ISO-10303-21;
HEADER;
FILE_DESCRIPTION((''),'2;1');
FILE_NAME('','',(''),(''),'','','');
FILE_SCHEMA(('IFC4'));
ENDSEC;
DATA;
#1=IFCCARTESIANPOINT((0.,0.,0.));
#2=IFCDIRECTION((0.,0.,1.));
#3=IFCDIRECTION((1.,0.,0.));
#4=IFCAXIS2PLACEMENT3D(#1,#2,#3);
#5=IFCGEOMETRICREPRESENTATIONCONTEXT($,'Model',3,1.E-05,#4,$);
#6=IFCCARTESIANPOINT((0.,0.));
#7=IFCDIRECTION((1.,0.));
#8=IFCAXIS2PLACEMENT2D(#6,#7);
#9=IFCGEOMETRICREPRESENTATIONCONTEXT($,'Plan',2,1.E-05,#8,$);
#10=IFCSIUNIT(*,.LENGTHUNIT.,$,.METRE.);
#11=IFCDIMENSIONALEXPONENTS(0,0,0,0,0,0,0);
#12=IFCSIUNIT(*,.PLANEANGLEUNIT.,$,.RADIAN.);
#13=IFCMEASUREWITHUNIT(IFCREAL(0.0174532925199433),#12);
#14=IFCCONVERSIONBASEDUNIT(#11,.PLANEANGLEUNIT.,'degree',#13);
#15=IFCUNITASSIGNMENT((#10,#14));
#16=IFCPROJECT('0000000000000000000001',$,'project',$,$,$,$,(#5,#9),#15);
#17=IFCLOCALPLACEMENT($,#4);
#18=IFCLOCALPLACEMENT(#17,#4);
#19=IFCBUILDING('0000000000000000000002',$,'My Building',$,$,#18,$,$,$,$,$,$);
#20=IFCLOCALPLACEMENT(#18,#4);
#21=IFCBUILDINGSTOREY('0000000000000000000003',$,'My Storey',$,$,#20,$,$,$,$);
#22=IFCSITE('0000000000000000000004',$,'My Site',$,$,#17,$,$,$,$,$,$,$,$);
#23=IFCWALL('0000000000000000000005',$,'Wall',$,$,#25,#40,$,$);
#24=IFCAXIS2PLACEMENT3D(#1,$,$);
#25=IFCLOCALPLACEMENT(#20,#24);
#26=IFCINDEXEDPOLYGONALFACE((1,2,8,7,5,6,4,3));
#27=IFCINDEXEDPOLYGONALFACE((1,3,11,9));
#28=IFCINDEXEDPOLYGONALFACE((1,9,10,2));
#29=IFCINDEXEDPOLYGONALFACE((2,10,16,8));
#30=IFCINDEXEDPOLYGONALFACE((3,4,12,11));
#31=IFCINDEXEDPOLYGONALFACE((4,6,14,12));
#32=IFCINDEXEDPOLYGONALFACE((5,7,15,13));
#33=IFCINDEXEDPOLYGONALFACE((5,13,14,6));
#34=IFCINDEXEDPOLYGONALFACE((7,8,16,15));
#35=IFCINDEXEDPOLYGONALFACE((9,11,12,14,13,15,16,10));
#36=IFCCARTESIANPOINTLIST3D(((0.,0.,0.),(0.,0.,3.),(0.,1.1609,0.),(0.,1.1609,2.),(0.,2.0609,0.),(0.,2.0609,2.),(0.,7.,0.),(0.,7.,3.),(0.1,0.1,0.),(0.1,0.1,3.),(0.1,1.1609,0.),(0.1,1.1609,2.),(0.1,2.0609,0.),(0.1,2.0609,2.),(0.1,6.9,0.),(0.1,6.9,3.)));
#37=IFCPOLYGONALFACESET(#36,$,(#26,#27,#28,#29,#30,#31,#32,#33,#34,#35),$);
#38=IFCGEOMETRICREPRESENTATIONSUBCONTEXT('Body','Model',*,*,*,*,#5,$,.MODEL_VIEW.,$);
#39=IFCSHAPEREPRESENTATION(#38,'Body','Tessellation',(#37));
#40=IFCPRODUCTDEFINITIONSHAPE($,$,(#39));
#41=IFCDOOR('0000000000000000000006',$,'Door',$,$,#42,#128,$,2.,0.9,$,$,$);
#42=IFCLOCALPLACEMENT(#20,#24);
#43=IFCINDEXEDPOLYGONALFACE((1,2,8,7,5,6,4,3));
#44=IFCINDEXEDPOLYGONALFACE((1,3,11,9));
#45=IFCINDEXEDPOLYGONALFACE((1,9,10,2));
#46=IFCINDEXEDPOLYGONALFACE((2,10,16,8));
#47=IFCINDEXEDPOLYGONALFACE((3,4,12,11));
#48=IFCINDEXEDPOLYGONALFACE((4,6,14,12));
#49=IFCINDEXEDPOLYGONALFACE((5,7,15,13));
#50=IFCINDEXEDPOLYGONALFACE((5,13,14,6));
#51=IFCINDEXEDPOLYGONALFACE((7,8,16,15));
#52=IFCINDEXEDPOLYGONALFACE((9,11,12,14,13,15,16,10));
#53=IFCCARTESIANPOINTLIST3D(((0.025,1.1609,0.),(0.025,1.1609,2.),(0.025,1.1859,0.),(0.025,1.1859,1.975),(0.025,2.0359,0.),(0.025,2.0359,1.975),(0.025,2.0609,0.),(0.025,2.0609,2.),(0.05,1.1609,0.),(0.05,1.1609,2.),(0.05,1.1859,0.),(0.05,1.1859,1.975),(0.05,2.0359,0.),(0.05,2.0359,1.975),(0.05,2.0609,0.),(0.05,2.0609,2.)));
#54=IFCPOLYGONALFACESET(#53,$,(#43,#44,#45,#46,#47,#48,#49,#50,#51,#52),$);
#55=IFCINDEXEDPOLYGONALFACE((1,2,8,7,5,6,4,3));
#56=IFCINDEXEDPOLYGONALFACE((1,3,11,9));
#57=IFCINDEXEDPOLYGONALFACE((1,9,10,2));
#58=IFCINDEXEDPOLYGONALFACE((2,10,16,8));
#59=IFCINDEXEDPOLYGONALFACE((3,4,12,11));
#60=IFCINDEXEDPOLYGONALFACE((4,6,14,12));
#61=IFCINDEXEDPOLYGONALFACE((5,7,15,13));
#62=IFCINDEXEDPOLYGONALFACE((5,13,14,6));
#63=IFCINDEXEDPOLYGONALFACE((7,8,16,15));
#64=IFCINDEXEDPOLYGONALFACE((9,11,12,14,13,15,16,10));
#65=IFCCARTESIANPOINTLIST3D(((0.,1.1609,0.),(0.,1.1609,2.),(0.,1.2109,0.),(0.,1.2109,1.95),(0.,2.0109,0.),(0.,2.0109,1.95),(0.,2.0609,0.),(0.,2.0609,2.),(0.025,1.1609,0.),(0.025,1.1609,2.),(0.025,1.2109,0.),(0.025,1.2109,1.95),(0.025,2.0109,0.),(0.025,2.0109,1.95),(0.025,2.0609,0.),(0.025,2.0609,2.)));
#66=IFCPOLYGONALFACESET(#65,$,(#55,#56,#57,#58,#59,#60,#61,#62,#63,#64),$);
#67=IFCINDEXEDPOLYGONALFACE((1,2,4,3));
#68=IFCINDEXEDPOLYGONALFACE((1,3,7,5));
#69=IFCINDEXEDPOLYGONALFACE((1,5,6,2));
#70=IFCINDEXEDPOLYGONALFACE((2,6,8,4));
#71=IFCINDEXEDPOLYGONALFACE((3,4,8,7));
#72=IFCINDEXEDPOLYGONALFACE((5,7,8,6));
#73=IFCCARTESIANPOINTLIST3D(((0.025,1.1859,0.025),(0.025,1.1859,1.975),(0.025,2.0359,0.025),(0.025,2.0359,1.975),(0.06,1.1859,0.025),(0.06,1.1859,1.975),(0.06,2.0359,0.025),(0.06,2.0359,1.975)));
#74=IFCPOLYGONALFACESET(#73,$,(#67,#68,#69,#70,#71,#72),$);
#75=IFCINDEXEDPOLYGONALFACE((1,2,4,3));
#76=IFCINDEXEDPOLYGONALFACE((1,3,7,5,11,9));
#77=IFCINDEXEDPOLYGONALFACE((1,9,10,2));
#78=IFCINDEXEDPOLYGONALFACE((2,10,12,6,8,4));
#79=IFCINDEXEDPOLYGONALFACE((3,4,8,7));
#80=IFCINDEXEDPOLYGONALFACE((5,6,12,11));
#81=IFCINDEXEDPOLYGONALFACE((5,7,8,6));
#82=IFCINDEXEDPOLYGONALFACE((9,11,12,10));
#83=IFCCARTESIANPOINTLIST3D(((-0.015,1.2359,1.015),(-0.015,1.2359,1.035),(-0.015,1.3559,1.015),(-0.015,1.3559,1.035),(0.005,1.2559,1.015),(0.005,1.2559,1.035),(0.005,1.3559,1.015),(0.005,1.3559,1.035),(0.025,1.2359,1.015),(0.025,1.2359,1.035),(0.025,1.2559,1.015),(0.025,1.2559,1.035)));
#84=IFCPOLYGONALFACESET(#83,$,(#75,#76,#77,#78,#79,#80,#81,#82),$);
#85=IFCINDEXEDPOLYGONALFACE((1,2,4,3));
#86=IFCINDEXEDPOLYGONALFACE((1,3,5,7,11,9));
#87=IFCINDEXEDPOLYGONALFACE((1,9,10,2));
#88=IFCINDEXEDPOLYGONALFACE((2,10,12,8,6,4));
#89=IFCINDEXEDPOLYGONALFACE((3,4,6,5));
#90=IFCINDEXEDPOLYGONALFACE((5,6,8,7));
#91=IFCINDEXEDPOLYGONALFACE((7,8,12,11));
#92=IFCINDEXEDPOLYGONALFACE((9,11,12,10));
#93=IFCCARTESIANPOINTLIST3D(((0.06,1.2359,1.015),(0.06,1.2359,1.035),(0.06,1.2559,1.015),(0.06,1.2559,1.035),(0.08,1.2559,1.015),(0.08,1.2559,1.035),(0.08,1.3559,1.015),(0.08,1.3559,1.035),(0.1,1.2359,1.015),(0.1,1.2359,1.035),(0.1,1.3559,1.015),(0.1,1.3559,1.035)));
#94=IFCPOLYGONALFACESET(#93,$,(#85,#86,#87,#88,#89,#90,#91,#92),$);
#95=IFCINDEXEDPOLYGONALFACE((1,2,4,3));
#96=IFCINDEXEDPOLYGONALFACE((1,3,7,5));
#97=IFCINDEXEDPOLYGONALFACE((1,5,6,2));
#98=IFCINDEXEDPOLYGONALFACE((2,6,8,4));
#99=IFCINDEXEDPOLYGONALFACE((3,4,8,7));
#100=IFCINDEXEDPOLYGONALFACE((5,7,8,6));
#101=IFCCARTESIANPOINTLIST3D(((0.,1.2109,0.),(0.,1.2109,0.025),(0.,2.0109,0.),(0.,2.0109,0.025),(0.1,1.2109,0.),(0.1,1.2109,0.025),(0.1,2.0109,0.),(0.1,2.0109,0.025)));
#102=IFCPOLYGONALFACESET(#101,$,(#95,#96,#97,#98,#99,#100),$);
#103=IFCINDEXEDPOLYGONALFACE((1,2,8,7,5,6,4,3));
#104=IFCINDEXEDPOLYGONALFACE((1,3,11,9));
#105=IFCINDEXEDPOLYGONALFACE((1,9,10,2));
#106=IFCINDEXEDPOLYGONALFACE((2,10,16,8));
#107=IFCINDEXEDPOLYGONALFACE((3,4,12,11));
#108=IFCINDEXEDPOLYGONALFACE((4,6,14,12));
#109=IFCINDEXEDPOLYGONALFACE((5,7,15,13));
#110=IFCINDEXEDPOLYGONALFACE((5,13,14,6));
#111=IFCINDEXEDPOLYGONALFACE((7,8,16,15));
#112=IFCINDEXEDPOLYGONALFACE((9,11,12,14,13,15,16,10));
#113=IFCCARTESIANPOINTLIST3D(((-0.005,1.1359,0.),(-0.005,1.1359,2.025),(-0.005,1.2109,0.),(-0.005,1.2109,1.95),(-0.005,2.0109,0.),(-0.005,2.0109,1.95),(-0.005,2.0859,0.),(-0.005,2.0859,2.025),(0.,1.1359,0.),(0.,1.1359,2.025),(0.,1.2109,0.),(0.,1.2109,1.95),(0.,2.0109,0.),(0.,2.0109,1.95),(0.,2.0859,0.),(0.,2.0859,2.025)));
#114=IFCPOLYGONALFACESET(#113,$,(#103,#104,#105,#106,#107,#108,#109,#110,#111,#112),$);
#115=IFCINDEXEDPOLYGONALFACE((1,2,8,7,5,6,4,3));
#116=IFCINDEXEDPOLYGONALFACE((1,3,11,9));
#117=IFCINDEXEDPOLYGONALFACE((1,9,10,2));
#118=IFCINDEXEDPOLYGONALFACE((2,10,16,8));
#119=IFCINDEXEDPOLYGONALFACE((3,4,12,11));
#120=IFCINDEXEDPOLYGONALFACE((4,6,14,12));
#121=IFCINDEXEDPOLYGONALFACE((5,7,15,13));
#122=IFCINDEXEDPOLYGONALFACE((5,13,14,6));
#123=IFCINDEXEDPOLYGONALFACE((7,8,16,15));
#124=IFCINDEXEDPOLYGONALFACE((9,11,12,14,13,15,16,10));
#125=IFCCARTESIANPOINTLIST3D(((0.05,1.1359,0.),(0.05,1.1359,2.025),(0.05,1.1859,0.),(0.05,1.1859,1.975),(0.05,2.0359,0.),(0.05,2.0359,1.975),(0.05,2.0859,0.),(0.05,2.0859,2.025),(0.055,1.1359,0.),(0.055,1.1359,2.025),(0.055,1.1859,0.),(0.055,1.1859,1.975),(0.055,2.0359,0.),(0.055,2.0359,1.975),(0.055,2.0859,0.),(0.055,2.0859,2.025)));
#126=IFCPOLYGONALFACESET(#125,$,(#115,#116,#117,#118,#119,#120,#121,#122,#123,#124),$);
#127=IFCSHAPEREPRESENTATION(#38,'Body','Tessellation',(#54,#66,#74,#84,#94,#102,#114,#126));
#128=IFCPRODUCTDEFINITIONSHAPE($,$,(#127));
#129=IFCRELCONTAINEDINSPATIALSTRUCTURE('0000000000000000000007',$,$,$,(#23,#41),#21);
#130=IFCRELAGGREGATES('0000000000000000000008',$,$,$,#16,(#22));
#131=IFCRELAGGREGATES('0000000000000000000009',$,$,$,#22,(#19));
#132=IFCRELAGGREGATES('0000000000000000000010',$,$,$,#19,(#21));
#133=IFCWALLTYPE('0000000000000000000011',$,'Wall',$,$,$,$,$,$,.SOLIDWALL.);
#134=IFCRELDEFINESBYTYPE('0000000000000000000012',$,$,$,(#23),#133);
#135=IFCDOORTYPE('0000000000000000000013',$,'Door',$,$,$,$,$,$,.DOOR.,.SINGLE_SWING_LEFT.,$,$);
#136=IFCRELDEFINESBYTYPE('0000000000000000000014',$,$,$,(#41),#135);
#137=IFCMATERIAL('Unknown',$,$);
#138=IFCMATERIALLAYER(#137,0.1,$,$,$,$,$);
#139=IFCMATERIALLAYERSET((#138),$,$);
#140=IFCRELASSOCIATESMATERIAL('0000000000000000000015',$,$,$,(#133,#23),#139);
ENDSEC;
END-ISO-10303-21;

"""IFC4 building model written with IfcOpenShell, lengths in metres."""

from ifc_helpers import new_model, entity, si_unit, converted_unit, frame, origin_with_axes, origin_2d_with_axis, place, context, subcontext, project, spatial, line, indexed_curve, outline, extrude, shape, source, transform, mapped, material, layer, layer_set, layer_usage, type_object, type_shapes, element, fill, save


model = new_model("IFC4")

# Units and contexts
model_context = context("Model", 3, precision=1e-05, world=origin_with_axes())
plan_context = context("Plan", 2, precision=1e-05, world=origin_2d_with_axis())
body_context_1 = subcontext(model_context, "Body", "Model", "MODEL_VIEW")
body_context_2 = subcontext(plan_context, "Body", "Plan", "PLAN_VIEW")
ifc_project = project(units=[si_unit("LENGTHUNIT", "METRE"), converted_unit("PLANEANGLEUNIT", "degree", entity("IfcReal", 0.0174532925199433), si_unit("PLANEANGLEUNIT", "RADIAN"), dimensions=[0, 0, 0, 0, 0, 0, 0])], contexts=[model_context, plan_context])

# Site, building, storey
site_placement = place(None, origin_with_axes())
site = spatial("IfcSite", under=ifc_project, at=site_placement, Name="My Site")
building_placement = place(site_placement, origin_with_axes())
building = spatial("IfcBuilding", under=site, at=building_placement, Name="My Building")
storey_placement = place(building_placement, origin_with_axes())
storey = spatial("IfcBuildingStorey", under=building, at=storey_placement, Name="My Storey")

# Shared definitions
ifc_material = material(Name="Unknown")

# Shared definitions
ifc_layer_1 = layer(ifc_material, 0.1)
ifc_layer_set_1 = layer_set([ifc_layer_1])
wall_type = type_object("IfcWallType", Name="Wall", PredefinedType="SOLIDWALL", material=ifc_layer_set_1)
shared_shape_1 = source(origin_with_axes(), body_context_1, "Body", "SweptSolid", [
    extrude(outline(indexed_curve([(0.0, 0.0), (0.9, 0.0), (0.9, 2.0), (0.0, 2.0)], segments=[line(1, 2, 3, 4, 1)])), frame((0.0, -0.6, 0.0), z_axis=(0.0, -1.0, 0.0), x_axis=(1.0, 0.0, 0.0)), (0.0, 0.0, -1.0), 1.2),
])
door_type = type_object("IfcDoorType", Name="Door", OperationType="SINGLE_SWING_LEFT", PredefinedType="DOOR")
shared_shape_2 = source(origin_with_axes(), body_context_1, "Body", "SweptSolid", [
    extrude(outline(indexed_curve([(0.0, 0.0), (0.0, 2.0), (0.9, 2.0), (0.9, 0.0), (0.875, 0.0), (0.875, 1.975), (0.025, 1.975), (0.025, 0.0)], segments=[line(1, 2, 3, 4, 5, 6, 7, 8, 1)])), frame((0.0, 0.025, 0.0), z_axis=(0.0, -1.0, 0.0), x_axis=(1.0, 0.0, 0.0)), (0.0, 0.0, -1.0), 0.025),
    extrude(outline(indexed_curve([(0.0, 0.0), (0.0, 2.0), (0.9, 2.0), (0.9, 0.0), (0.85, 0.0), (0.85, 1.95), (0.05, 1.95), (0.05, 0.0)], segments=[line(1, 2, 3, 4, 5, 6, 7, 8, 1)])), frame((0.0, 0.0, 0.0), z_axis=(0.0, -1.0, 0.0), x_axis=(1.0, 0.0, 0.0)), (0.0, 0.0, -1.0), 0.025),
    extrude(outline(indexed_curve([(0.0, 0.0), (0.85, 0.0), (0.85, 0.035), (0.0, 0.035)], segments=[line(1, 2, 3, 4, 1)])), frame((0.025, 0.025, 0.025), z_axis=(0.0, 0.0, 1.0), x_axis=(1.0, 0.0, 0.0)), (0.0, 0.0, 1.0), 1.95),
    extrude(outline(indexed_curve([(0.0, 0.0), (0.0, -0.04), (-0.12, -0.04), (-0.12, -0.02), (-0.02, -0.02), (-0.02, 0.0)], segments=[line(1, 2, 3, 4, 5, 6, 1)])), frame((0.825, 0.025, 1.015), z_axis=(0.0, 0.0, 1.0), x_axis=(1.0, 0.0, 0.0)), (0.0, 0.0, 1.0), 0.02),
    extrude(outline(indexed_curve([(0.0, 0.0), (0.0, 0.04), (-0.12, 0.04), (-0.12, 0.02), (-0.02, 0.02), (-0.02, 0.0)], segments=[line(1, 2, 3, 4, 5, 6, 1)])), frame((0.825, 0.06, 1.015), z_axis=(0.0, 0.0, 1.0), x_axis=(1.0, 0.0, 0.0)), (0.0, 0.0, 1.0), 0.02),
    extrude(outline(indexed_curve([(0.0, 0.0), (0.8, 0.0), (0.8, 0.1), (0.0, 0.1)], segments=[line(1, 2, 3, 4, 1)])), frame((0.05, 0.0, 0.0), z_axis=(0.0, 0.0, 1.0), x_axis=(1.0, 0.0, 0.0)), (0.0, 0.0, 1.0), 0.025),
    extrude(outline(indexed_curve([(0.0, 0.0), (0.0, 2.025), (0.95, 2.025), (0.95, 0.0), (0.875, 0.0), (0.875, 1.95), (0.075, 1.95), (0.075, 0.0)], segments=[line(1, 2, 3, 4, 5, 6, 7, 8, 1)])), frame((-0.025, -0.005, 0.0), z_axis=(0.0, -1.0, 0.0), x_axis=(1.0, 0.0, 0.0)), (0.0, 0.0, -1.0), 0.005),
    extrude(outline(indexed_curve([(0.0, 0.0), (0.0, 2.025), (0.95, 2.025), (0.95, 0.0), (0.9, 0.0), (0.9, 1.975), (0.05, 1.975), (0.05, 0.0)], segments=[line(1, 2, 3, 4, 5, 6, 7, 8, 1)])), frame((-0.025, 0.05, 0.0), z_axis=(0.0, -1.0, 0.0), x_axis=(1.0, 0.0, 0.0)), (0.0, 0.0, -1.0), 0.005),
])
shared_shape_3 = source(origin_with_axes(), body_context_2, "Body", "Curve2D", [
    entity("IfcIndexedPolyCurve", entity("IfcCartesianPointList2D", [[0.0, 0.0], [0.0, 0.05], [0.025, 0.05], [0.025, 0.025], [0.05, 0.025], [0.05, 0.0]]), [entity("IfcLineIndex", [1, 2, 3, 4, 5, 6, 1])]),
    entity("IfcIndexedPolyCurve", entity("IfcCartesianPointList2D", [[0.9, 0.0], [0.9, 0.05], [0.875, 0.05], [0.875, 0.025], [0.85, 0.025], [0.85, 0.0]]), [entity("IfcLineIndex", [1, 2, 3, 4, 5, 6, 1])]),
    entity("IfcTrimmedCurve", entity("IfcEllipse", entity("IfcAxis2Placement2D", entity("IfcCartesianPoint", [0.06, 0.05]), entity("IfcDirection", [1.0, 0.0])), 0.815, 0.85), [entity("IfcCartesianPoint", [0.875, 0.05])], [entity("IfcCartesianPoint", [0.06, 0.9])], True, "CARTESIAN"),
    entity("IfcIndexedPolyCurve", entity("IfcCartesianPointList2D", [[0.025, 0.05], [0.06, 0.05], [0.06, 0.9], [0.025, 0.9]]), [entity("IfcLineIndex", [1, 2, 3, 4, 1])]),
])
type_shapes(door_type, [shared_shape_2, shared_shape_3])

# Wall, opening, door
ifc_layer_usage_1 = layer_usage(ifc_layer_set_1, "AXIS2", "POSITIVE", 0.0)
wall_1_placement = place(storey_placement, frame((0.0, 7.0, 0.0), z_axis=(0.0, 0.0, 1.0), x_axis=(0.0, -1.0, 0.0)))
wall_1 = element("IfcWall", 1, at=wall_1_placement, inside=storey, type_object=wall_type, material=ifc_layer_usage_1, Name="Wall", context=body_context_1, shape_type="SweptSolid", body=[
    extrude(outline(indexed_curve([(0.0, 0.0), (0.1, 0.1), (6.9, 0.1), (7.0, 0.0)], segments=[line(1, 2, 3, 4, 1)])), origin_with_axes(), (0.0, 0.0, 1.0), 3.0),
])
opening_1_placement = place(wall_1_placement, frame((4.9391, 0.0, 0.0), z_axis=(0.0, 0.0, 1.0), x_axis=(1.0, 0.0, 0.0)))
opening_1 = element("IfcOpeningElement", 2, at=opening_1_placement, cuts=wall_1, PredefinedType="OPENING", context=body_context_1, shape_type="MappedRepresentation", body=[
    mapped(shared_shape_1, transform((0.0, 0.0, 0.0), x_axis=(1.0, 0.0, 0.0), y_axis=(0.0, 1.0, 0.0), z_axis=(0.0, 0.0, 1.0), scale=1.0)),
])
door_1_placement = place(opening_1_placement, frame((0.0, 0.0, 0.0), z_axis=(0.0, 0.0, 1.0), x_axis=(1.0, 0.0, 0.0)))
door_1 = element("IfcDoor", 3, at=door_1_placement, inside=storey, type_object=door_type, Name="Door", OverallHeight=2.0, OverallWidth=0.9, shapes=[
    shape(body_context_1, "Body", "MappedRepresentation", [mapped(shared_shape_2, transform((0.0, 0.0, 0.0), x_axis=(1.0, 0.0, 0.0), y_axis=(0.0, 1.0, 0.0), z_axis=(0.0, 0.0, 1.0), scale=1.0))]),
    shape(body_context_2, "Body", "MappedRepresentation", [mapped(shared_shape_3, transform((0.0, 0.0, 0.0), x_axis=(1.0, 0.0, 0.0), y_axis=(0.0, 1.0, 0.0), z_axis=(0.0, 0.0, 1.0), scale=1.0))]),
])
fill(opening_1, door_1)

save(model, "model.ifc")
